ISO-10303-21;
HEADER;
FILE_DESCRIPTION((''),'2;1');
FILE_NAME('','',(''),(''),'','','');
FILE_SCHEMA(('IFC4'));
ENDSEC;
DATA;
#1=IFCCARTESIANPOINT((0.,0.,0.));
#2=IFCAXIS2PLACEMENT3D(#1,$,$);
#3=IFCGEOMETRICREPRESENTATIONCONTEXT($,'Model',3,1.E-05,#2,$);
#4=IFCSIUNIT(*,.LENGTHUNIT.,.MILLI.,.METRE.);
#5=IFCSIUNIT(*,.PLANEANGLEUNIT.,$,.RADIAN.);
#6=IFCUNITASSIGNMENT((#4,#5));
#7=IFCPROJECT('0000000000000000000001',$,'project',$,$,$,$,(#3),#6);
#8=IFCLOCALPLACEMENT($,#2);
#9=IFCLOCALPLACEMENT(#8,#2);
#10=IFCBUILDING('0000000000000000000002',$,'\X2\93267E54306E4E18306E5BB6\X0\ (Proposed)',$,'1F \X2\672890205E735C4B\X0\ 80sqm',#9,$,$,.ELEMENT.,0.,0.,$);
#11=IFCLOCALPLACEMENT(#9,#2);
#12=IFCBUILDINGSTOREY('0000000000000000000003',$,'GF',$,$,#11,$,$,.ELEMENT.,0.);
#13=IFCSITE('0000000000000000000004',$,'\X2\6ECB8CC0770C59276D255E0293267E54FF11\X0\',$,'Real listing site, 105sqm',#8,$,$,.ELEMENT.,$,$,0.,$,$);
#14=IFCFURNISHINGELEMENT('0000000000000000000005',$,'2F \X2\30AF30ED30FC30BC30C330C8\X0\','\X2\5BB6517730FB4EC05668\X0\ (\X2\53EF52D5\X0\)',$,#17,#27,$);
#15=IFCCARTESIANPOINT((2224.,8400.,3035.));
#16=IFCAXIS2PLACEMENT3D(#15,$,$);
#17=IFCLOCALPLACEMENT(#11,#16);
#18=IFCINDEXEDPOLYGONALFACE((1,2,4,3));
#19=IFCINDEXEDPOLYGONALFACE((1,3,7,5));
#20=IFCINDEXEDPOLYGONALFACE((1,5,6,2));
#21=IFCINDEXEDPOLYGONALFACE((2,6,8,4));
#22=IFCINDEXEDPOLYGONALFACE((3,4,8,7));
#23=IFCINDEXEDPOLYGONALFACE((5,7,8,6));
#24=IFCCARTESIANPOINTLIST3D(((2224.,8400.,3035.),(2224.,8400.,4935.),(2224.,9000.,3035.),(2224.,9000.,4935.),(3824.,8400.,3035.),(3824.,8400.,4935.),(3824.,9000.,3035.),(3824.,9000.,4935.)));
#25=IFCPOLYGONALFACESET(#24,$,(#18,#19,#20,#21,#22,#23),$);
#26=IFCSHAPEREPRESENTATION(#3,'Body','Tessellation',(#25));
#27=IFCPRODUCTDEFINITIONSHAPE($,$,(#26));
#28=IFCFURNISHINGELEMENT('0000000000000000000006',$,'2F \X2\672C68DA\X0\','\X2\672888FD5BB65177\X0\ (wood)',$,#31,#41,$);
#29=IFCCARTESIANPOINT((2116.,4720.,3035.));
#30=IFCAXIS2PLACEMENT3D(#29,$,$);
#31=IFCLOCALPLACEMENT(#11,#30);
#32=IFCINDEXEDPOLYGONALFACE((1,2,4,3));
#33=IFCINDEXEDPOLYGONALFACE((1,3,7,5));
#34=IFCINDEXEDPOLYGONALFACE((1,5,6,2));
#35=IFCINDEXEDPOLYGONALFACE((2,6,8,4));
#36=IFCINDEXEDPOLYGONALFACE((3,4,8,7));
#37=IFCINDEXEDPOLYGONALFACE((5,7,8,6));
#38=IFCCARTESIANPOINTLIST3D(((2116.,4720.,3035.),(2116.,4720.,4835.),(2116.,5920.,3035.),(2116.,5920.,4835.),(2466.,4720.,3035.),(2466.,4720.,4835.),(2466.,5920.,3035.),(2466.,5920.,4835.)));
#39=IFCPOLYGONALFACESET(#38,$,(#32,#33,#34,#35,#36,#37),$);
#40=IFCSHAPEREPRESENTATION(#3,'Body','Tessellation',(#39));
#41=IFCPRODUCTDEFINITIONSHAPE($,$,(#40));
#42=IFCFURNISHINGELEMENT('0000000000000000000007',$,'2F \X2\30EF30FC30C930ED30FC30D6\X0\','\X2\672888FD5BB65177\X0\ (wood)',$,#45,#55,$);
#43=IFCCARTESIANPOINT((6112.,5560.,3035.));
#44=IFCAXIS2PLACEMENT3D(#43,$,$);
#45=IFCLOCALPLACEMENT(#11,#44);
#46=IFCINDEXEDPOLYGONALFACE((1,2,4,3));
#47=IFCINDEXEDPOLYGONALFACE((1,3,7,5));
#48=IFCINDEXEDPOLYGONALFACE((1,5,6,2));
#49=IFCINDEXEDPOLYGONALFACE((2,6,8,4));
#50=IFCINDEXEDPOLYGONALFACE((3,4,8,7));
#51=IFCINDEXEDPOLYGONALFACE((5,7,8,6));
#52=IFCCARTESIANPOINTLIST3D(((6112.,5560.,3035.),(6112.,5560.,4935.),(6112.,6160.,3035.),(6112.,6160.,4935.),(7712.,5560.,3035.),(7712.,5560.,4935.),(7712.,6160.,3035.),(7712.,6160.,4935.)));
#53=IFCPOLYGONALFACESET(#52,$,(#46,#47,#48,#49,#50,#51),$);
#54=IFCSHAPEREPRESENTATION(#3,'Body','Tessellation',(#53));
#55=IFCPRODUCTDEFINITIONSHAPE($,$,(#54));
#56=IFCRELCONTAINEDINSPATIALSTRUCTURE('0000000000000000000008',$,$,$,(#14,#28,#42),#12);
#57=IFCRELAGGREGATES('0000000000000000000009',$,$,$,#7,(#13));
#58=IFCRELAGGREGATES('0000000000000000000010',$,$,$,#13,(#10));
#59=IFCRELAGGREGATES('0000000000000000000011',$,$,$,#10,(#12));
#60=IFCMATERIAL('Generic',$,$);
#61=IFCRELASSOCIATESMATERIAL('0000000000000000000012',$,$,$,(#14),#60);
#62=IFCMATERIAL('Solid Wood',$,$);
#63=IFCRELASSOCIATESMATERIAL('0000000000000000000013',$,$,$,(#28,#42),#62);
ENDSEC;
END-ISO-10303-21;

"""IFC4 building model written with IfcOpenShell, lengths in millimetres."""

from ifc_helpers import new_model, si_unit, frame, frame_2d, origin, place, context, project, spatial, rectangle, extrude, material, element, save


model = new_model("IFC4")

# Units and contexts
model_context = context("Model", 3, precision=1e-05, world=origin())
ifc_project = project(units=[si_unit("LENGTHUNIT", "METRE", prefix="MILLI"), si_unit("PLANEANGLEUNIT", "RADIAN")], contexts=[model_context])

# Site, building, storey
site_placement = place(None, origin())
site = spatial("IfcSite", under=ifc_project, at=site_placement, Name="滋賀県大津市錦織１", ObjectType="Real listing site, 105sqm", CompositionType="ELEMENT", RefElevation=0.0)
building_placement = place(site_placement, origin())
building = spatial("IfcBuilding", under=site, at=building_placement, Name="錦織の丘の家 (Proposed)", ObjectType="1F 木造平屋 80sqm", CompositionType="ELEMENT", ElevationOfRefHeight=0.0, ElevationOfTerrain=0.0)
storey_placement = place(building_placement, origin())
storey = spatial("IfcBuildingStorey", under=building, at=storey_placement, Name="GF", CompositionType="ELEMENT", Elevation=0.0)

# Shared definitions
ifc_material_1 = material(Name="Solid Wood")

# Shared definitions
ifc_material_2 = material(Name="Generic")

# Furnishing elements
furnishing_1_placement = place(storey_placement, frame((2224.0, 8400.0, 3035.0)))
element("IfcFurnishingElement", 1, at=furnishing_1_placement, inside=storey, material=ifc_material_2, Name="2F クローゼット", Description="家具・什器 (可動)", context=model_context, shape_type="SweptSolid", body=[
    extrude(rectangle(XDim=1600.0, YDim=600.0, at=frame_2d((800.0, 300.0))), frame((2224.0, 8400.0, 3035.0)), (0.0, 0.0, 1.0), 1900.0),
])
furnishing_2_placement = place(storey_placement, frame((2116.0, 4720.0, 3035.0)))
element("IfcFurnishingElement", 2, at=furnishing_2_placement, inside=storey, material=ifc_material_1, Name="2F 本棚", Description="木製家具 (wood)", context=model_context, shape_type="SweptSolid", body=[
    extrude(rectangle(XDim=350.0, YDim=1200.0, at=frame_2d((175.0, 600.0))), frame((2116.0, 4720.0, 3035.0)), (0.0, 0.0, 1.0), 1800.0),
])
furnishing_3_placement = place(storey_placement, frame((6112.0, 5560.0, 3035.0)))
element("IfcFurnishingElement", 3, at=furnishing_3_placement, inside=storey, material=ifc_material_1, Name="2F ワードローブ", Description="木製家具 (wood)", context=model_context, shape_type="SweptSolid", body=[
    extrude(rectangle(XDim=1600.0, YDim=600.0, at=frame_2d((800.0, 300.0))), frame((6112.0, 5560.0, 3035.0)), (0.0, 0.0, 1.0), 1900.0),
])

save(model, "model.ifc")
